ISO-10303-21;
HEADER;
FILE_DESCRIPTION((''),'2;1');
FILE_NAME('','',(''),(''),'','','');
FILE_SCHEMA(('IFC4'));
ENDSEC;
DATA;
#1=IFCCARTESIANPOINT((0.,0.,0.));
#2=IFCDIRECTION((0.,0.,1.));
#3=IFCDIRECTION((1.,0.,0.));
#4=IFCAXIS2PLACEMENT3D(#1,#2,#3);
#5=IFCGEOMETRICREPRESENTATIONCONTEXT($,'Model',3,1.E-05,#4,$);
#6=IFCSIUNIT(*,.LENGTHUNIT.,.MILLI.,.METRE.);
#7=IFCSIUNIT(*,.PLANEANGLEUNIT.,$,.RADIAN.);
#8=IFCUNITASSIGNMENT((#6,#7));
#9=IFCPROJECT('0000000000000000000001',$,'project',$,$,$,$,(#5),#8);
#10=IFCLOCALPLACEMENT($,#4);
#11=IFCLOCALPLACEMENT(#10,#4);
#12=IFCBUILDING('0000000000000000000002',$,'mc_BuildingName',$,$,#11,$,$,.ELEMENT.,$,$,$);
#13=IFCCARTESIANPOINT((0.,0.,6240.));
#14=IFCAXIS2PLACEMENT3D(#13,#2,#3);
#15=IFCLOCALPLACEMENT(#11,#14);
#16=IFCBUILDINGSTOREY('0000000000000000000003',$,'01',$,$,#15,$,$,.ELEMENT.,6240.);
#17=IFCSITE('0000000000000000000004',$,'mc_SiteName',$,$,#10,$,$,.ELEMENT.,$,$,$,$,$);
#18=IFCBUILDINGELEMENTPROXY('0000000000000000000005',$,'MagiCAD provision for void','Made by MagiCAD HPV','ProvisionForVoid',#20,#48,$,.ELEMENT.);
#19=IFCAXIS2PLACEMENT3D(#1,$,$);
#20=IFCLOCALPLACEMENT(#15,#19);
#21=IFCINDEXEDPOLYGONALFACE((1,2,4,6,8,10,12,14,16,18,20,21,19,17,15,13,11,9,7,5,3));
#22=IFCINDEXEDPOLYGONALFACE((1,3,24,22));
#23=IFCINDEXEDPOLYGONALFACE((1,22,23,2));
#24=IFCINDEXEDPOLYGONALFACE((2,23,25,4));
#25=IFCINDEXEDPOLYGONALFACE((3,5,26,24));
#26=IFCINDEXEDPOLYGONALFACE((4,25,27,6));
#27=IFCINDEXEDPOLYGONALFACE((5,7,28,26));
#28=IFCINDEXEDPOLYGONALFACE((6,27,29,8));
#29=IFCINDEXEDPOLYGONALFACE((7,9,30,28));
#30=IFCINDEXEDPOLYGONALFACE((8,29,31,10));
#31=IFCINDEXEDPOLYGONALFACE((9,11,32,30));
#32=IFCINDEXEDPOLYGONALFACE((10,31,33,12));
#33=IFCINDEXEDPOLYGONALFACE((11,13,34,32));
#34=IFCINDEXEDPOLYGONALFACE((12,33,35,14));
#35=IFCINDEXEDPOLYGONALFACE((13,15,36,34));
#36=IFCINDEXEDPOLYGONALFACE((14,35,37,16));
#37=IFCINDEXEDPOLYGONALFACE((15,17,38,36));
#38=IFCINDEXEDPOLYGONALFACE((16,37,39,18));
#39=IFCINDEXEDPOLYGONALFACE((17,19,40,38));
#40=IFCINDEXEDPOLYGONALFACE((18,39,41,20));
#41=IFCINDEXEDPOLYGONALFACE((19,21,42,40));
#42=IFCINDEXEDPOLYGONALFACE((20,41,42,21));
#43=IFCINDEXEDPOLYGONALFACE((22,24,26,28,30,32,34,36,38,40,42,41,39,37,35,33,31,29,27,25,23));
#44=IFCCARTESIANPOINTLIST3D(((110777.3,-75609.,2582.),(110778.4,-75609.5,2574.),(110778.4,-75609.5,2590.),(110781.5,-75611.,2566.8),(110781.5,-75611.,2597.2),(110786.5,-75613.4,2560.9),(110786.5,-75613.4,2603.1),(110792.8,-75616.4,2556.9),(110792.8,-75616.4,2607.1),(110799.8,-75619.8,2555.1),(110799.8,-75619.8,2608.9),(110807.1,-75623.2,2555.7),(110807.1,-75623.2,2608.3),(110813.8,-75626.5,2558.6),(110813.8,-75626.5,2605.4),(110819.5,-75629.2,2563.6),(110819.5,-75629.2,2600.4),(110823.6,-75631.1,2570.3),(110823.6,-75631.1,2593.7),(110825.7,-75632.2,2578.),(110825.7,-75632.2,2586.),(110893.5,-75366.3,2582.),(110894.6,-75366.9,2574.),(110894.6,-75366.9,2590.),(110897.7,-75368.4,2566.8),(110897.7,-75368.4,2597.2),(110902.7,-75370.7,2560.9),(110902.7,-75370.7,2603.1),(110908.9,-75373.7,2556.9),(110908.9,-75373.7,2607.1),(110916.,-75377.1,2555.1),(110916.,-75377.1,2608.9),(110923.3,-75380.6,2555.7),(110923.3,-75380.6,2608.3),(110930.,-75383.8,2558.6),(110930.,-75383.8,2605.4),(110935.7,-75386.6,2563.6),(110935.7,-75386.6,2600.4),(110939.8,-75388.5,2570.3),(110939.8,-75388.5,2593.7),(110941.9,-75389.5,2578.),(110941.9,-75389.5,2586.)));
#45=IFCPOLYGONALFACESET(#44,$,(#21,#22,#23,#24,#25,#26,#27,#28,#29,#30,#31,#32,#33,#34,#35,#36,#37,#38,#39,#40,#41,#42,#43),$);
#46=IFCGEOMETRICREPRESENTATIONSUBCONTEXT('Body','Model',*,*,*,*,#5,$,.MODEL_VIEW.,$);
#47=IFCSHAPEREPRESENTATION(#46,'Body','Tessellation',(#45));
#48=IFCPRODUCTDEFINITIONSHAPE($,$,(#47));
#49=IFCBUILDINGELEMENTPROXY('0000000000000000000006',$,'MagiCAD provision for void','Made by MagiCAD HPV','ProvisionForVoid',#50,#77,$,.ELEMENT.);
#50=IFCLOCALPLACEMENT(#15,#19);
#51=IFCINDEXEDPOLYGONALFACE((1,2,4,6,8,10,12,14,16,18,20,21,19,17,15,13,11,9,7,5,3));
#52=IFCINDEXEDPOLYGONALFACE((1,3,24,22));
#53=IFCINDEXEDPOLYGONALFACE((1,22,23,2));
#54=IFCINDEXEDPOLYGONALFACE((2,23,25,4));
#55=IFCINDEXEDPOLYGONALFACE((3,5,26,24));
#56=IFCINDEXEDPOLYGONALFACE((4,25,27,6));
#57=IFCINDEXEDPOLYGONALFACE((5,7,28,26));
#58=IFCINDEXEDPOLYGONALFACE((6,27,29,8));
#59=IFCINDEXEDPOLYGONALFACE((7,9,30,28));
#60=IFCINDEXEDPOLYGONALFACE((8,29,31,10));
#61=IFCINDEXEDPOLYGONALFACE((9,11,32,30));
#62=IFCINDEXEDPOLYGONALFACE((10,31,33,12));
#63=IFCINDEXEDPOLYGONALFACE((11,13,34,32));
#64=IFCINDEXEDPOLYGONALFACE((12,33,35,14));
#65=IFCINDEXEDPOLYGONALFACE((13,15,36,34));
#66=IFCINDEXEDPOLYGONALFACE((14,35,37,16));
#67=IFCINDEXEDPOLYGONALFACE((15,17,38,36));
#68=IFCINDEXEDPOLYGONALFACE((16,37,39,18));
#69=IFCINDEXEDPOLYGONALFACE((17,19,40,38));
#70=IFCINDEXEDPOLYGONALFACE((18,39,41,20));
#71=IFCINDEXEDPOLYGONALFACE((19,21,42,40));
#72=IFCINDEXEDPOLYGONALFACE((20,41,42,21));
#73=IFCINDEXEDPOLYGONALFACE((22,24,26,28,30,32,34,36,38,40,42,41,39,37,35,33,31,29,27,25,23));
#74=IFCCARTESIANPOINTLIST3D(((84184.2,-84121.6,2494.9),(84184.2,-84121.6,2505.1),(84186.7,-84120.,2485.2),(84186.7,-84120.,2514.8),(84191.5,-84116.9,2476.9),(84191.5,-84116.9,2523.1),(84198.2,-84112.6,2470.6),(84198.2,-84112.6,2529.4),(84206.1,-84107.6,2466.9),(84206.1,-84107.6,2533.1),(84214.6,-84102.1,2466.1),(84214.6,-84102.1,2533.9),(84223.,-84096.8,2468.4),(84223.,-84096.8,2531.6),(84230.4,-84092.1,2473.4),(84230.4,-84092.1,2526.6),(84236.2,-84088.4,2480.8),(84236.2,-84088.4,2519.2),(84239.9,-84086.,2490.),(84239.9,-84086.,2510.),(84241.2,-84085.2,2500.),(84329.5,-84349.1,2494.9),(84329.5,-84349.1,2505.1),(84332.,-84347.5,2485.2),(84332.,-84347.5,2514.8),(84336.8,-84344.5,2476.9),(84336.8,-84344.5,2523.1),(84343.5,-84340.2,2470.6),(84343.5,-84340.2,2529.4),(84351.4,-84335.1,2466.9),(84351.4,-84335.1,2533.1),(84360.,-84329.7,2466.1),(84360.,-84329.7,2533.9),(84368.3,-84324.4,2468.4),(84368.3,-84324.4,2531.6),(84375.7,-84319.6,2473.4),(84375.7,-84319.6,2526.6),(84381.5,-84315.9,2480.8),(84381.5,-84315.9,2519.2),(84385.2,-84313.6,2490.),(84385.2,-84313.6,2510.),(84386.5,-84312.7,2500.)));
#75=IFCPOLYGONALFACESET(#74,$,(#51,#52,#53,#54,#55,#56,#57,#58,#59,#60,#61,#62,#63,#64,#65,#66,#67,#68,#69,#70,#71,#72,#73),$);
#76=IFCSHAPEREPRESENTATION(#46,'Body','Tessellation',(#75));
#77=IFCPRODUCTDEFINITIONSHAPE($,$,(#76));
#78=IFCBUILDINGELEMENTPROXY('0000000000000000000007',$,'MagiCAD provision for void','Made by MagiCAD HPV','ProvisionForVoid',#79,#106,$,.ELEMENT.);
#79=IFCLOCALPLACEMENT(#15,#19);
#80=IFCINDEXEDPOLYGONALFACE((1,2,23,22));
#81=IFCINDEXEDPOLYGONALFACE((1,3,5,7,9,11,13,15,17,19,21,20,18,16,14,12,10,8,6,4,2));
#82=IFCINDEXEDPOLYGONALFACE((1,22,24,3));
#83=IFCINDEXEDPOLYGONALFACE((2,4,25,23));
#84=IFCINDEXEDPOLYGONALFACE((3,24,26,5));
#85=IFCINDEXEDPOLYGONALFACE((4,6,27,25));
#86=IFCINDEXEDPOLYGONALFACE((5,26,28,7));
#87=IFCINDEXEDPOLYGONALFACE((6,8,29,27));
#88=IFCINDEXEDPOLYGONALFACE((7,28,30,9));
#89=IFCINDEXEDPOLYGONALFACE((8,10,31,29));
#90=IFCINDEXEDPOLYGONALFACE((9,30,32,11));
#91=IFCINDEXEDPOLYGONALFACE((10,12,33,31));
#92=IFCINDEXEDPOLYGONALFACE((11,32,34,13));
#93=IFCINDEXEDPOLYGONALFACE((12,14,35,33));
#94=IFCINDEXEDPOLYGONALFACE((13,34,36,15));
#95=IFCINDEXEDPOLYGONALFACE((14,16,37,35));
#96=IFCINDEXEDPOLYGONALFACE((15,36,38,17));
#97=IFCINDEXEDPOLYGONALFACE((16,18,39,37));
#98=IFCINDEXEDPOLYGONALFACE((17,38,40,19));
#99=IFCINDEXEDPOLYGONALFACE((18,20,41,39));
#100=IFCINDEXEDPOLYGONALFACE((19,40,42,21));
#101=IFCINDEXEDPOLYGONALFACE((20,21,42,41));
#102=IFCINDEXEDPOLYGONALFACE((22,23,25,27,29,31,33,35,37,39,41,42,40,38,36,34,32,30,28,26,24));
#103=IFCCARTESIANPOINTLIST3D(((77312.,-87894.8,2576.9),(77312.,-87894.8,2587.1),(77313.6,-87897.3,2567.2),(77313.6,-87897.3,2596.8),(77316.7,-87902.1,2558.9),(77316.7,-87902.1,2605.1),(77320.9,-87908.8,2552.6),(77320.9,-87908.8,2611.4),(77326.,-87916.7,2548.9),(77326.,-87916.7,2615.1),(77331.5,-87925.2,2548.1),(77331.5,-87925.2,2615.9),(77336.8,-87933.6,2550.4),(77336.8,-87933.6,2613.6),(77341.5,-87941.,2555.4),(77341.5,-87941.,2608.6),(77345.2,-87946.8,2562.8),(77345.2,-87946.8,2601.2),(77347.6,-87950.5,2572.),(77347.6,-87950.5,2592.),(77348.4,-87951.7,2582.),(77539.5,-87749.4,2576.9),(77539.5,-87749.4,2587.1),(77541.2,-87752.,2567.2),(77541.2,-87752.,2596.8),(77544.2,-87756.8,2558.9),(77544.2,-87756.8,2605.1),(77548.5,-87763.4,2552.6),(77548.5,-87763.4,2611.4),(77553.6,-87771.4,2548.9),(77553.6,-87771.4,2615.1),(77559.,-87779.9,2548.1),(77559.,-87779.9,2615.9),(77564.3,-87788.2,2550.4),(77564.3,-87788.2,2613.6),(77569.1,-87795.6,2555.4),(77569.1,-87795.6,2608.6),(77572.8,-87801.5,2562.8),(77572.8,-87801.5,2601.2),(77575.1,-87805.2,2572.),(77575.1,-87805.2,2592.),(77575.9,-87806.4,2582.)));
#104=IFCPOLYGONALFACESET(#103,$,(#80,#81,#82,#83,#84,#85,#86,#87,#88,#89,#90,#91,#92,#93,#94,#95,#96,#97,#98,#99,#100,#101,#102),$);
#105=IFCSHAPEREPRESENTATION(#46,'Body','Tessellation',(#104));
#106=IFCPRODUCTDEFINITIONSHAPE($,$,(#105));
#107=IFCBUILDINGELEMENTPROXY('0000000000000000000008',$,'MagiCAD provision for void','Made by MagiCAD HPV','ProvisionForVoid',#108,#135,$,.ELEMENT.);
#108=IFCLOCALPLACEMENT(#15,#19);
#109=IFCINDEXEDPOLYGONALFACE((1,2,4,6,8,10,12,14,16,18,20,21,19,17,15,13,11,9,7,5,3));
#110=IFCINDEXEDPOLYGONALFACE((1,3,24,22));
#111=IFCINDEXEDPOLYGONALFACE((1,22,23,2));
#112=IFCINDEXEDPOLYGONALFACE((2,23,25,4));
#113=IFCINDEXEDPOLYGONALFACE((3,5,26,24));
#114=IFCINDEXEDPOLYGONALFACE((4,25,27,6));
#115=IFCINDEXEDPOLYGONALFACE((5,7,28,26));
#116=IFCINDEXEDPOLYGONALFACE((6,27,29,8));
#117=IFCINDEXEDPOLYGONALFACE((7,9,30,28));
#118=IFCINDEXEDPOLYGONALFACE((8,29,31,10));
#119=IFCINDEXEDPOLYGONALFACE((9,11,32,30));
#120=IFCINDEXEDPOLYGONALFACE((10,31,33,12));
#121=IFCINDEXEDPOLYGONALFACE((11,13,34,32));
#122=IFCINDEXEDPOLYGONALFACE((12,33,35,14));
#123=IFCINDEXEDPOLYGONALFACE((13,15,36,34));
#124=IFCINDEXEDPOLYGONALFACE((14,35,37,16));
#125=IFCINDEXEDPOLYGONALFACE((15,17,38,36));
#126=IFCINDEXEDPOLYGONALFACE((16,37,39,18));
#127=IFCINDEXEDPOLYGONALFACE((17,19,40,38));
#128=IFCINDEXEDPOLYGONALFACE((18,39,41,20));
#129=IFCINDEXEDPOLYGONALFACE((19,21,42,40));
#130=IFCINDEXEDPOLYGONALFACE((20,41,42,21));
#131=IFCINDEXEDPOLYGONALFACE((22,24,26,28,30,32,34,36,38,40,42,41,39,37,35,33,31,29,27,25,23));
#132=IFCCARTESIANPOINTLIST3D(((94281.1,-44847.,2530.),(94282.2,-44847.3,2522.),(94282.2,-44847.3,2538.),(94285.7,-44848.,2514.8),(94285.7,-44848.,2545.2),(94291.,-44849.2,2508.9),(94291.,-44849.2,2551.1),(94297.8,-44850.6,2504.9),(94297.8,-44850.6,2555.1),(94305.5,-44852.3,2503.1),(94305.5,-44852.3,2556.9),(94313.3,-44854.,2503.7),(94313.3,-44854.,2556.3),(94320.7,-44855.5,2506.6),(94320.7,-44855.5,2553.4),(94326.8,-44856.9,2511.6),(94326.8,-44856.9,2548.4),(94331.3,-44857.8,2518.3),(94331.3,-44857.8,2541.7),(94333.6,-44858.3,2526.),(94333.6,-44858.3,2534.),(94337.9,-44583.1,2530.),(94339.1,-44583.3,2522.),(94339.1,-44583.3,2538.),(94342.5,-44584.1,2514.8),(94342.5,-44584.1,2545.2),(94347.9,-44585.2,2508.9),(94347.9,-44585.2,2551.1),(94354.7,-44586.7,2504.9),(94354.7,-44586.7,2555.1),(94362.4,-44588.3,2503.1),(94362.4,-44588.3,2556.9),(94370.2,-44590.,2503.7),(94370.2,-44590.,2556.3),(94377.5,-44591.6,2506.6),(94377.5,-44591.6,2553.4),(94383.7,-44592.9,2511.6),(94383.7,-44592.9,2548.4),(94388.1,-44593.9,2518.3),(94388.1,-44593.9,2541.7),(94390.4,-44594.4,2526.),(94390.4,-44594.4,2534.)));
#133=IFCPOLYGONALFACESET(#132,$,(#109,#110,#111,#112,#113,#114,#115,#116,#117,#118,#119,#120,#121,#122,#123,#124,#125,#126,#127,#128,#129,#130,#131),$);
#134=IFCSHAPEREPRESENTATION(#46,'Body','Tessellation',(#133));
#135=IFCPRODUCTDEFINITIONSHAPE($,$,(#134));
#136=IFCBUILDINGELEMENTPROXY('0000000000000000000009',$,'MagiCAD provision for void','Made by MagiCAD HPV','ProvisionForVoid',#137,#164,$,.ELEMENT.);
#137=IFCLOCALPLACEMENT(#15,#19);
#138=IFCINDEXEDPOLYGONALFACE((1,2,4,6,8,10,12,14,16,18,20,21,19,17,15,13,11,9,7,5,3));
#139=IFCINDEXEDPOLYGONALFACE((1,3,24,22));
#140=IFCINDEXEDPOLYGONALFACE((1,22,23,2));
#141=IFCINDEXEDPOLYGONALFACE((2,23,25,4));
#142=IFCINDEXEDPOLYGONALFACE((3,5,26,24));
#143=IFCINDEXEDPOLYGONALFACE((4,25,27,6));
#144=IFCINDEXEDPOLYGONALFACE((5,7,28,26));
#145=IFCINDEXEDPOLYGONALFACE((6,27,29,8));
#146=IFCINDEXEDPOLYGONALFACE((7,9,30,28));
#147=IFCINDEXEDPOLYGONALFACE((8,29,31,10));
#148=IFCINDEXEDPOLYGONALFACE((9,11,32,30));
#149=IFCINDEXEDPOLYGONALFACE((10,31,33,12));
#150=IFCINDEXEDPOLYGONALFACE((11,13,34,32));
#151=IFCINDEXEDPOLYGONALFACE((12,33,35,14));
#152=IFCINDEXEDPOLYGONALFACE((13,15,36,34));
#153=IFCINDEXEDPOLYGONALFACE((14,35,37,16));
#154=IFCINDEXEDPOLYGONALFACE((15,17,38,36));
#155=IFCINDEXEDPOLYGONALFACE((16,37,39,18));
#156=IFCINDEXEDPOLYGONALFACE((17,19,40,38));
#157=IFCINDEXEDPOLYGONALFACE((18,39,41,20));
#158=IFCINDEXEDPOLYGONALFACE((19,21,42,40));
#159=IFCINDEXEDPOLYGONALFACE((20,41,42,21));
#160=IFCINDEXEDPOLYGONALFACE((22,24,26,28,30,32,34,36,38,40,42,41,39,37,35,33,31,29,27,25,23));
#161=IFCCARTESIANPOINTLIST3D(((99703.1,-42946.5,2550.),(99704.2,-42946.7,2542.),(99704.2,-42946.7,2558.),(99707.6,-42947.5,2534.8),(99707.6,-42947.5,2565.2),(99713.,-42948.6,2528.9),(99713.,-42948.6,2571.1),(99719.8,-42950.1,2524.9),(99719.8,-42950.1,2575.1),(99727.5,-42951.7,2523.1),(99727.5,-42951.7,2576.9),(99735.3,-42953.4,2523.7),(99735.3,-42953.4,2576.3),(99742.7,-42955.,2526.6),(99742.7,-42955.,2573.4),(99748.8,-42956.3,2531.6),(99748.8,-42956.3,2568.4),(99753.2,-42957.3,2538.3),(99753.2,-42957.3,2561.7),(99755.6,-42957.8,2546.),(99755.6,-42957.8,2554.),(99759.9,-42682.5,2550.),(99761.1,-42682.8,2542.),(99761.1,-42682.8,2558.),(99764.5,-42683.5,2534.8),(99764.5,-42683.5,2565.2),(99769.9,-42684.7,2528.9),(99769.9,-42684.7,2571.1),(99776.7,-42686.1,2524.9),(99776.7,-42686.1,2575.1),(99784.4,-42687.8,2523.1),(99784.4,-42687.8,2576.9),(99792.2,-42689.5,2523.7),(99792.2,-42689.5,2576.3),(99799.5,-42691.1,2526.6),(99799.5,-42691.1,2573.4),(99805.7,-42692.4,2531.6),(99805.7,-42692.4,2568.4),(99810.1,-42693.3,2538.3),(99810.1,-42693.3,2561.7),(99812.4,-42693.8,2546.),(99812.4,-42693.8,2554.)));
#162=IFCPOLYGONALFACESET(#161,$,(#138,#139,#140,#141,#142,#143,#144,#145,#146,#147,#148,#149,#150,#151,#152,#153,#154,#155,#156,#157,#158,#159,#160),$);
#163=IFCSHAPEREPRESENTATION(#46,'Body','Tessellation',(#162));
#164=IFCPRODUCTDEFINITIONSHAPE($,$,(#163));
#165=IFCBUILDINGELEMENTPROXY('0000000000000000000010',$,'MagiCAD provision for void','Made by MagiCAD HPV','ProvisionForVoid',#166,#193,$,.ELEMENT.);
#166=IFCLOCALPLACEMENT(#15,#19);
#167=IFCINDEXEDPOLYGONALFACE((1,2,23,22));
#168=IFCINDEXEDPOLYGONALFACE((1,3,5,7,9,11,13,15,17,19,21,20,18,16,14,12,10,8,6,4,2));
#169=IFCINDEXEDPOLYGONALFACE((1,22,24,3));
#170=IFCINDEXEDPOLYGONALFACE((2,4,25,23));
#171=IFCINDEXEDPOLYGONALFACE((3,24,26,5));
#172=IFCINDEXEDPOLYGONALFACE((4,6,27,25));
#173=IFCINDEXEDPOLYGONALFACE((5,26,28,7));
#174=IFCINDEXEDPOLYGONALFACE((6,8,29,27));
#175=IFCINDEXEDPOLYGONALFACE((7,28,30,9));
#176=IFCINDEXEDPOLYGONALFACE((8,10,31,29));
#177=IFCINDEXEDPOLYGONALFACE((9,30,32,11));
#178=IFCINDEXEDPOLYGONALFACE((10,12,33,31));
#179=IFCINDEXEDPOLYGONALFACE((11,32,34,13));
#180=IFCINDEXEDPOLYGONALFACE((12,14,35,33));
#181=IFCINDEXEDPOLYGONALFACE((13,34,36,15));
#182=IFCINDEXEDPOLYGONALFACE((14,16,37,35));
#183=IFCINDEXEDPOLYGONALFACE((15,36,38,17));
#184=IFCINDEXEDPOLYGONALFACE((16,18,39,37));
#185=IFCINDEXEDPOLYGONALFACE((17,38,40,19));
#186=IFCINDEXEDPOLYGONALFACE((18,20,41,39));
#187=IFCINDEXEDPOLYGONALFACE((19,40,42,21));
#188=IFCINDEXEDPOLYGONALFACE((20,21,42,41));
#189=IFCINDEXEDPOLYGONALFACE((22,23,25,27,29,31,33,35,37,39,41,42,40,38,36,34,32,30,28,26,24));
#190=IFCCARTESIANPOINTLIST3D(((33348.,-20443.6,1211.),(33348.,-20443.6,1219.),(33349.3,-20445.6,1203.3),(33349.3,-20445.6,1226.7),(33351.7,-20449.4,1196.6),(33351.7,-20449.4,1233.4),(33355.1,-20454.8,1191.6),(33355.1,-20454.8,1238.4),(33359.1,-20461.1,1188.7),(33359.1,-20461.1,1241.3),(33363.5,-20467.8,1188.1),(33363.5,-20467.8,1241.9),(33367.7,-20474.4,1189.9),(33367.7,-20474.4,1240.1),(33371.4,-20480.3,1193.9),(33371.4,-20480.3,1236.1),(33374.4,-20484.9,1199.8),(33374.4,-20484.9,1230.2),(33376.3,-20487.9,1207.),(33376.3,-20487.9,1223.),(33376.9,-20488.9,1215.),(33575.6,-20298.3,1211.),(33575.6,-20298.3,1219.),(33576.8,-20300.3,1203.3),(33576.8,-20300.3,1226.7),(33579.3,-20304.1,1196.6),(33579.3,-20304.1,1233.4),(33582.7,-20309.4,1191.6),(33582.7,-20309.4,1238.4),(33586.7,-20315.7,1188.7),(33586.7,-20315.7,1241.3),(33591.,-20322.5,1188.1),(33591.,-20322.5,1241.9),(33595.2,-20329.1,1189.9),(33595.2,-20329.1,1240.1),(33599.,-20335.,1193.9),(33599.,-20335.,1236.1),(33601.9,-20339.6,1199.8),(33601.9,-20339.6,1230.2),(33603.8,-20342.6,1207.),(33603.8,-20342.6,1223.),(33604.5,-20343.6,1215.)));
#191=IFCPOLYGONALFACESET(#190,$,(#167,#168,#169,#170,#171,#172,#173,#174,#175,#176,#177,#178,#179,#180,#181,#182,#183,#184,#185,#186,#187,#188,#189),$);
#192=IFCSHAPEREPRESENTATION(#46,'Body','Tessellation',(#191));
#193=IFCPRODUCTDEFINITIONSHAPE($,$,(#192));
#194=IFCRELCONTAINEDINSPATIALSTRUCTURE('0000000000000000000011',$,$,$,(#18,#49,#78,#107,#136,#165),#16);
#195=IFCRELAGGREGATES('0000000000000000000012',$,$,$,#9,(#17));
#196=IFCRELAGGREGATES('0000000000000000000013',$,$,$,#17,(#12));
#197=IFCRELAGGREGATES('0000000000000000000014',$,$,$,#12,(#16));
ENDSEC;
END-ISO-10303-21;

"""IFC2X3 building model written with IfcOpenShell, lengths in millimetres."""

from ifc_helpers import new_model, si_unit, frame, origin_with_axes, origin_2d_with_axis, place, context, subcontext, project, spatial, circle, extrude, source, transform, mapped, element, save


model = new_model("IFC2X3")

# Units and contexts
model_context = context("Model", 3, precision=1e-05, world=origin_with_axes())
body_context = subcontext(model_context, "Body", "Model", "MODEL_VIEW")
ifc_project = project(units=[si_unit("LENGTHUNIT", "METRE", prefix="MILLI"), si_unit("PLANEANGLEUNIT", "RADIAN")], contexts=[model_context])

# Site, building, storey
site_placement = place(None, origin_with_axes())
site = spatial("IfcSite", under=ifc_project, at=site_placement, Name="mc_SiteName", CompositionType="ELEMENT")
building_placement = place(site_placement, origin_with_axes())
building = spatial("IfcBuilding", under=site, at=building_placement, Name="mc_BuildingName", CompositionType="ELEMENT")
storey_placement = place(building_placement, frame((0.0, 0.0, 6240.0), z_axis=(0.0, 0.0, 1.0), x_axis=(1.0, 0.0, 0.0)))
storey = spatial("IfcBuildingStorey", under=building, at=storey_placement, Name="01", CompositionType="ELEMENT", Elevation=6240.0)

# Building element proxies
shared_shape_1 = source(origin_with_axes(), body_context, "Body", "SweptSolid", [
    extrude(circle(Radius=27.0, at=origin_2d_with_axis()), frame((0.0, 0.0, 0.0), z_axis=(1.0, 0.0, 0.0), x_axis=(0.0, 1.0, 0.0)), (0.0, 0.0, 1.0), 269.0),
])
proxy_1_placement = place(storey_placement, frame((110801.7, -75620.6, 2582.0), z_axis=(0.0, 0.0, 1.0), x_axis=(0.431859, 0.901941, 0.0)))
element("IfcBuildingElementProxy", 1, at=proxy_1_placement, inside=storey, Name="MagiCAD provision for void", Description="Made by MagiCAD HPV", ObjectType="ProvisionForVoid", CompositionType="ELEMENT", context=body_context, shape_type="MappedRepresentation", body=[
    mapped(shared_shape_1, transform((0.0, 0.0, 0.0), scale=1.0)),
])
shared_shape_2 = source(origin_with_axes(), body_context, "Body", "SweptSolid", [
    extrude(circle(Radius=34.0, at=origin_2d_with_axis()), frame((0.0, 0.0, 0.0), z_axis=(1.0, 0.0, 0.0), x_axis=(0.0, 1.0, 0.0)), (0.0, 0.0, 1.0), 270.0),
])
proxy_2_placement = place(storey_placement, frame((84212.5, -84103.5, 2500.0), z_axis=(0.0, 0.0, 1.0), x_axis=(0.538213, -0.842809, 0.0)))
element("IfcBuildingElementProxy", 2, at=proxy_2_placement, inside=storey, Name="MagiCAD provision for void", Description="Made by MagiCAD HPV", ObjectType="ProvisionForVoid", CompositionType="ELEMENT", context=body_context, shape_type="MappedRepresentation", body=[
    mapped(shared_shape_2, transform((0.0, 0.0, 0.0), scale=1.0)),
])
shared_shape_3 = source(origin_with_axes(), body_context, "Body", "SweptSolid", [
    extrude(circle(Radius=34.0, at=origin_2d_with_axis()), frame((0.0, 0.0, 0.0), z_axis=(1.0, 0.0, 0.0), x_axis=(0.0, 1.0, 0.0)), (0.0, 0.0, 1.0), 270.0),
])
proxy_3_placement = place(storey_placement, frame((77557.6, -87777.8, 2582.0), z_axis=(0.0, 0.0, 1.0), x_axis=(-0.842809, -0.538213, 0.0)))
element("IfcBuildingElementProxy", 3, at=proxy_3_placement, inside=storey, Name="MagiCAD provision for void", Description="Made by MagiCAD HPV", ObjectType="ProvisionForVoid", CompositionType="ELEMENT", context=body_context, shape_type="MappedRepresentation", body=[
    mapped(shared_shape_3, transform((0.0, 0.0, 0.0), scale=1.0)),
])
shared_shape_4 = source(origin_with_axes(), body_context, "Body", "SweptSolid", [
    extrude(circle(Radius=27.0, at=origin_2d_with_axis()), frame((0.0, 0.0, 0.0), z_axis=(1.0, 0.0, 0.0), x_axis=(0.0, 1.0, 0.0)), (0.0, 0.0, 1.0), 270.0),
])
proxy_4_placement = place(storey_placement, frame((94307.5, -44852.7, 2530.0), z_axis=(0.0, 0.0, 1.0), x_axis=(0.210642, 0.977563, 0.0)))
element("IfcBuildingElementProxy", 4, at=proxy_4_placement, inside=storey, Name="MagiCAD provision for void", Description="Made by MagiCAD HPV", ObjectType="ProvisionForVoid", CompositionType="ELEMENT", context=body_context, shape_type="MappedRepresentation", body=[
    mapped(shared_shape_4, transform((0.0, 0.0, 0.0), scale=1.0)),
])
shared_shape_5 = source(origin_with_axes(), body_context, "Body", "SweptSolid", [
    extrude(circle(Radius=27.0, at=origin_2d_with_axis()), frame((0.0, 0.0, 0.0), z_axis=(1.0, 0.0, 0.0), x_axis=(0.0, 1.0, 0.0)), (0.0, 0.0, 1.0), 270.0),
])
proxy_5_placement = place(storey_placement, frame((99729.5, -42952.2, 2550.0), z_axis=(0.0, 0.0, 1.0), x_axis=(0.210642, 0.977563, 0.0)))
element("IfcBuildingElementProxy", 5, at=proxy_5_placement, inside=storey, Name="MagiCAD provision for void", Description="Made by MagiCAD HPV", ObjectType="ProvisionForVoid", CompositionType="ELEMENT", context=body_context, shape_type="MappedRepresentation", body=[
    mapped(shared_shape_5, transform((0.0, 0.0, 0.0), scale=1.0)),
])
shared_shape_6 = source(origin_with_axes(), body_context, "Body", "SweptSolid", [
    extrude(circle(Radius=27.0, at=origin_2d_with_axis()), frame((0.0, 0.0, 0.0), z_axis=(1.0, 0.0, 0.0), x_axis=(0.0, 1.0, 0.0)), (0.0, 0.0, 1.0), 270.0),
])
proxy_6_placement = place(storey_placement, frame((33589.9, -20320.8, 1215.0), z_axis=(0.0, 0.0, 1.0), x_axis=(-0.842809, -0.538213, 0.0)))
element("IfcBuildingElementProxy", 6, at=proxy_6_placement, inside=storey, Name="MagiCAD provision for void", Description="Made by MagiCAD HPV", ObjectType="ProvisionForVoid", CompositionType="ELEMENT", context=body_context, shape_type="MappedRepresentation", body=[
    mapped(shared_shape_6, transform((0.0, 0.0, 0.0), scale=1.0)),
])

save(model, "model.ifc")
